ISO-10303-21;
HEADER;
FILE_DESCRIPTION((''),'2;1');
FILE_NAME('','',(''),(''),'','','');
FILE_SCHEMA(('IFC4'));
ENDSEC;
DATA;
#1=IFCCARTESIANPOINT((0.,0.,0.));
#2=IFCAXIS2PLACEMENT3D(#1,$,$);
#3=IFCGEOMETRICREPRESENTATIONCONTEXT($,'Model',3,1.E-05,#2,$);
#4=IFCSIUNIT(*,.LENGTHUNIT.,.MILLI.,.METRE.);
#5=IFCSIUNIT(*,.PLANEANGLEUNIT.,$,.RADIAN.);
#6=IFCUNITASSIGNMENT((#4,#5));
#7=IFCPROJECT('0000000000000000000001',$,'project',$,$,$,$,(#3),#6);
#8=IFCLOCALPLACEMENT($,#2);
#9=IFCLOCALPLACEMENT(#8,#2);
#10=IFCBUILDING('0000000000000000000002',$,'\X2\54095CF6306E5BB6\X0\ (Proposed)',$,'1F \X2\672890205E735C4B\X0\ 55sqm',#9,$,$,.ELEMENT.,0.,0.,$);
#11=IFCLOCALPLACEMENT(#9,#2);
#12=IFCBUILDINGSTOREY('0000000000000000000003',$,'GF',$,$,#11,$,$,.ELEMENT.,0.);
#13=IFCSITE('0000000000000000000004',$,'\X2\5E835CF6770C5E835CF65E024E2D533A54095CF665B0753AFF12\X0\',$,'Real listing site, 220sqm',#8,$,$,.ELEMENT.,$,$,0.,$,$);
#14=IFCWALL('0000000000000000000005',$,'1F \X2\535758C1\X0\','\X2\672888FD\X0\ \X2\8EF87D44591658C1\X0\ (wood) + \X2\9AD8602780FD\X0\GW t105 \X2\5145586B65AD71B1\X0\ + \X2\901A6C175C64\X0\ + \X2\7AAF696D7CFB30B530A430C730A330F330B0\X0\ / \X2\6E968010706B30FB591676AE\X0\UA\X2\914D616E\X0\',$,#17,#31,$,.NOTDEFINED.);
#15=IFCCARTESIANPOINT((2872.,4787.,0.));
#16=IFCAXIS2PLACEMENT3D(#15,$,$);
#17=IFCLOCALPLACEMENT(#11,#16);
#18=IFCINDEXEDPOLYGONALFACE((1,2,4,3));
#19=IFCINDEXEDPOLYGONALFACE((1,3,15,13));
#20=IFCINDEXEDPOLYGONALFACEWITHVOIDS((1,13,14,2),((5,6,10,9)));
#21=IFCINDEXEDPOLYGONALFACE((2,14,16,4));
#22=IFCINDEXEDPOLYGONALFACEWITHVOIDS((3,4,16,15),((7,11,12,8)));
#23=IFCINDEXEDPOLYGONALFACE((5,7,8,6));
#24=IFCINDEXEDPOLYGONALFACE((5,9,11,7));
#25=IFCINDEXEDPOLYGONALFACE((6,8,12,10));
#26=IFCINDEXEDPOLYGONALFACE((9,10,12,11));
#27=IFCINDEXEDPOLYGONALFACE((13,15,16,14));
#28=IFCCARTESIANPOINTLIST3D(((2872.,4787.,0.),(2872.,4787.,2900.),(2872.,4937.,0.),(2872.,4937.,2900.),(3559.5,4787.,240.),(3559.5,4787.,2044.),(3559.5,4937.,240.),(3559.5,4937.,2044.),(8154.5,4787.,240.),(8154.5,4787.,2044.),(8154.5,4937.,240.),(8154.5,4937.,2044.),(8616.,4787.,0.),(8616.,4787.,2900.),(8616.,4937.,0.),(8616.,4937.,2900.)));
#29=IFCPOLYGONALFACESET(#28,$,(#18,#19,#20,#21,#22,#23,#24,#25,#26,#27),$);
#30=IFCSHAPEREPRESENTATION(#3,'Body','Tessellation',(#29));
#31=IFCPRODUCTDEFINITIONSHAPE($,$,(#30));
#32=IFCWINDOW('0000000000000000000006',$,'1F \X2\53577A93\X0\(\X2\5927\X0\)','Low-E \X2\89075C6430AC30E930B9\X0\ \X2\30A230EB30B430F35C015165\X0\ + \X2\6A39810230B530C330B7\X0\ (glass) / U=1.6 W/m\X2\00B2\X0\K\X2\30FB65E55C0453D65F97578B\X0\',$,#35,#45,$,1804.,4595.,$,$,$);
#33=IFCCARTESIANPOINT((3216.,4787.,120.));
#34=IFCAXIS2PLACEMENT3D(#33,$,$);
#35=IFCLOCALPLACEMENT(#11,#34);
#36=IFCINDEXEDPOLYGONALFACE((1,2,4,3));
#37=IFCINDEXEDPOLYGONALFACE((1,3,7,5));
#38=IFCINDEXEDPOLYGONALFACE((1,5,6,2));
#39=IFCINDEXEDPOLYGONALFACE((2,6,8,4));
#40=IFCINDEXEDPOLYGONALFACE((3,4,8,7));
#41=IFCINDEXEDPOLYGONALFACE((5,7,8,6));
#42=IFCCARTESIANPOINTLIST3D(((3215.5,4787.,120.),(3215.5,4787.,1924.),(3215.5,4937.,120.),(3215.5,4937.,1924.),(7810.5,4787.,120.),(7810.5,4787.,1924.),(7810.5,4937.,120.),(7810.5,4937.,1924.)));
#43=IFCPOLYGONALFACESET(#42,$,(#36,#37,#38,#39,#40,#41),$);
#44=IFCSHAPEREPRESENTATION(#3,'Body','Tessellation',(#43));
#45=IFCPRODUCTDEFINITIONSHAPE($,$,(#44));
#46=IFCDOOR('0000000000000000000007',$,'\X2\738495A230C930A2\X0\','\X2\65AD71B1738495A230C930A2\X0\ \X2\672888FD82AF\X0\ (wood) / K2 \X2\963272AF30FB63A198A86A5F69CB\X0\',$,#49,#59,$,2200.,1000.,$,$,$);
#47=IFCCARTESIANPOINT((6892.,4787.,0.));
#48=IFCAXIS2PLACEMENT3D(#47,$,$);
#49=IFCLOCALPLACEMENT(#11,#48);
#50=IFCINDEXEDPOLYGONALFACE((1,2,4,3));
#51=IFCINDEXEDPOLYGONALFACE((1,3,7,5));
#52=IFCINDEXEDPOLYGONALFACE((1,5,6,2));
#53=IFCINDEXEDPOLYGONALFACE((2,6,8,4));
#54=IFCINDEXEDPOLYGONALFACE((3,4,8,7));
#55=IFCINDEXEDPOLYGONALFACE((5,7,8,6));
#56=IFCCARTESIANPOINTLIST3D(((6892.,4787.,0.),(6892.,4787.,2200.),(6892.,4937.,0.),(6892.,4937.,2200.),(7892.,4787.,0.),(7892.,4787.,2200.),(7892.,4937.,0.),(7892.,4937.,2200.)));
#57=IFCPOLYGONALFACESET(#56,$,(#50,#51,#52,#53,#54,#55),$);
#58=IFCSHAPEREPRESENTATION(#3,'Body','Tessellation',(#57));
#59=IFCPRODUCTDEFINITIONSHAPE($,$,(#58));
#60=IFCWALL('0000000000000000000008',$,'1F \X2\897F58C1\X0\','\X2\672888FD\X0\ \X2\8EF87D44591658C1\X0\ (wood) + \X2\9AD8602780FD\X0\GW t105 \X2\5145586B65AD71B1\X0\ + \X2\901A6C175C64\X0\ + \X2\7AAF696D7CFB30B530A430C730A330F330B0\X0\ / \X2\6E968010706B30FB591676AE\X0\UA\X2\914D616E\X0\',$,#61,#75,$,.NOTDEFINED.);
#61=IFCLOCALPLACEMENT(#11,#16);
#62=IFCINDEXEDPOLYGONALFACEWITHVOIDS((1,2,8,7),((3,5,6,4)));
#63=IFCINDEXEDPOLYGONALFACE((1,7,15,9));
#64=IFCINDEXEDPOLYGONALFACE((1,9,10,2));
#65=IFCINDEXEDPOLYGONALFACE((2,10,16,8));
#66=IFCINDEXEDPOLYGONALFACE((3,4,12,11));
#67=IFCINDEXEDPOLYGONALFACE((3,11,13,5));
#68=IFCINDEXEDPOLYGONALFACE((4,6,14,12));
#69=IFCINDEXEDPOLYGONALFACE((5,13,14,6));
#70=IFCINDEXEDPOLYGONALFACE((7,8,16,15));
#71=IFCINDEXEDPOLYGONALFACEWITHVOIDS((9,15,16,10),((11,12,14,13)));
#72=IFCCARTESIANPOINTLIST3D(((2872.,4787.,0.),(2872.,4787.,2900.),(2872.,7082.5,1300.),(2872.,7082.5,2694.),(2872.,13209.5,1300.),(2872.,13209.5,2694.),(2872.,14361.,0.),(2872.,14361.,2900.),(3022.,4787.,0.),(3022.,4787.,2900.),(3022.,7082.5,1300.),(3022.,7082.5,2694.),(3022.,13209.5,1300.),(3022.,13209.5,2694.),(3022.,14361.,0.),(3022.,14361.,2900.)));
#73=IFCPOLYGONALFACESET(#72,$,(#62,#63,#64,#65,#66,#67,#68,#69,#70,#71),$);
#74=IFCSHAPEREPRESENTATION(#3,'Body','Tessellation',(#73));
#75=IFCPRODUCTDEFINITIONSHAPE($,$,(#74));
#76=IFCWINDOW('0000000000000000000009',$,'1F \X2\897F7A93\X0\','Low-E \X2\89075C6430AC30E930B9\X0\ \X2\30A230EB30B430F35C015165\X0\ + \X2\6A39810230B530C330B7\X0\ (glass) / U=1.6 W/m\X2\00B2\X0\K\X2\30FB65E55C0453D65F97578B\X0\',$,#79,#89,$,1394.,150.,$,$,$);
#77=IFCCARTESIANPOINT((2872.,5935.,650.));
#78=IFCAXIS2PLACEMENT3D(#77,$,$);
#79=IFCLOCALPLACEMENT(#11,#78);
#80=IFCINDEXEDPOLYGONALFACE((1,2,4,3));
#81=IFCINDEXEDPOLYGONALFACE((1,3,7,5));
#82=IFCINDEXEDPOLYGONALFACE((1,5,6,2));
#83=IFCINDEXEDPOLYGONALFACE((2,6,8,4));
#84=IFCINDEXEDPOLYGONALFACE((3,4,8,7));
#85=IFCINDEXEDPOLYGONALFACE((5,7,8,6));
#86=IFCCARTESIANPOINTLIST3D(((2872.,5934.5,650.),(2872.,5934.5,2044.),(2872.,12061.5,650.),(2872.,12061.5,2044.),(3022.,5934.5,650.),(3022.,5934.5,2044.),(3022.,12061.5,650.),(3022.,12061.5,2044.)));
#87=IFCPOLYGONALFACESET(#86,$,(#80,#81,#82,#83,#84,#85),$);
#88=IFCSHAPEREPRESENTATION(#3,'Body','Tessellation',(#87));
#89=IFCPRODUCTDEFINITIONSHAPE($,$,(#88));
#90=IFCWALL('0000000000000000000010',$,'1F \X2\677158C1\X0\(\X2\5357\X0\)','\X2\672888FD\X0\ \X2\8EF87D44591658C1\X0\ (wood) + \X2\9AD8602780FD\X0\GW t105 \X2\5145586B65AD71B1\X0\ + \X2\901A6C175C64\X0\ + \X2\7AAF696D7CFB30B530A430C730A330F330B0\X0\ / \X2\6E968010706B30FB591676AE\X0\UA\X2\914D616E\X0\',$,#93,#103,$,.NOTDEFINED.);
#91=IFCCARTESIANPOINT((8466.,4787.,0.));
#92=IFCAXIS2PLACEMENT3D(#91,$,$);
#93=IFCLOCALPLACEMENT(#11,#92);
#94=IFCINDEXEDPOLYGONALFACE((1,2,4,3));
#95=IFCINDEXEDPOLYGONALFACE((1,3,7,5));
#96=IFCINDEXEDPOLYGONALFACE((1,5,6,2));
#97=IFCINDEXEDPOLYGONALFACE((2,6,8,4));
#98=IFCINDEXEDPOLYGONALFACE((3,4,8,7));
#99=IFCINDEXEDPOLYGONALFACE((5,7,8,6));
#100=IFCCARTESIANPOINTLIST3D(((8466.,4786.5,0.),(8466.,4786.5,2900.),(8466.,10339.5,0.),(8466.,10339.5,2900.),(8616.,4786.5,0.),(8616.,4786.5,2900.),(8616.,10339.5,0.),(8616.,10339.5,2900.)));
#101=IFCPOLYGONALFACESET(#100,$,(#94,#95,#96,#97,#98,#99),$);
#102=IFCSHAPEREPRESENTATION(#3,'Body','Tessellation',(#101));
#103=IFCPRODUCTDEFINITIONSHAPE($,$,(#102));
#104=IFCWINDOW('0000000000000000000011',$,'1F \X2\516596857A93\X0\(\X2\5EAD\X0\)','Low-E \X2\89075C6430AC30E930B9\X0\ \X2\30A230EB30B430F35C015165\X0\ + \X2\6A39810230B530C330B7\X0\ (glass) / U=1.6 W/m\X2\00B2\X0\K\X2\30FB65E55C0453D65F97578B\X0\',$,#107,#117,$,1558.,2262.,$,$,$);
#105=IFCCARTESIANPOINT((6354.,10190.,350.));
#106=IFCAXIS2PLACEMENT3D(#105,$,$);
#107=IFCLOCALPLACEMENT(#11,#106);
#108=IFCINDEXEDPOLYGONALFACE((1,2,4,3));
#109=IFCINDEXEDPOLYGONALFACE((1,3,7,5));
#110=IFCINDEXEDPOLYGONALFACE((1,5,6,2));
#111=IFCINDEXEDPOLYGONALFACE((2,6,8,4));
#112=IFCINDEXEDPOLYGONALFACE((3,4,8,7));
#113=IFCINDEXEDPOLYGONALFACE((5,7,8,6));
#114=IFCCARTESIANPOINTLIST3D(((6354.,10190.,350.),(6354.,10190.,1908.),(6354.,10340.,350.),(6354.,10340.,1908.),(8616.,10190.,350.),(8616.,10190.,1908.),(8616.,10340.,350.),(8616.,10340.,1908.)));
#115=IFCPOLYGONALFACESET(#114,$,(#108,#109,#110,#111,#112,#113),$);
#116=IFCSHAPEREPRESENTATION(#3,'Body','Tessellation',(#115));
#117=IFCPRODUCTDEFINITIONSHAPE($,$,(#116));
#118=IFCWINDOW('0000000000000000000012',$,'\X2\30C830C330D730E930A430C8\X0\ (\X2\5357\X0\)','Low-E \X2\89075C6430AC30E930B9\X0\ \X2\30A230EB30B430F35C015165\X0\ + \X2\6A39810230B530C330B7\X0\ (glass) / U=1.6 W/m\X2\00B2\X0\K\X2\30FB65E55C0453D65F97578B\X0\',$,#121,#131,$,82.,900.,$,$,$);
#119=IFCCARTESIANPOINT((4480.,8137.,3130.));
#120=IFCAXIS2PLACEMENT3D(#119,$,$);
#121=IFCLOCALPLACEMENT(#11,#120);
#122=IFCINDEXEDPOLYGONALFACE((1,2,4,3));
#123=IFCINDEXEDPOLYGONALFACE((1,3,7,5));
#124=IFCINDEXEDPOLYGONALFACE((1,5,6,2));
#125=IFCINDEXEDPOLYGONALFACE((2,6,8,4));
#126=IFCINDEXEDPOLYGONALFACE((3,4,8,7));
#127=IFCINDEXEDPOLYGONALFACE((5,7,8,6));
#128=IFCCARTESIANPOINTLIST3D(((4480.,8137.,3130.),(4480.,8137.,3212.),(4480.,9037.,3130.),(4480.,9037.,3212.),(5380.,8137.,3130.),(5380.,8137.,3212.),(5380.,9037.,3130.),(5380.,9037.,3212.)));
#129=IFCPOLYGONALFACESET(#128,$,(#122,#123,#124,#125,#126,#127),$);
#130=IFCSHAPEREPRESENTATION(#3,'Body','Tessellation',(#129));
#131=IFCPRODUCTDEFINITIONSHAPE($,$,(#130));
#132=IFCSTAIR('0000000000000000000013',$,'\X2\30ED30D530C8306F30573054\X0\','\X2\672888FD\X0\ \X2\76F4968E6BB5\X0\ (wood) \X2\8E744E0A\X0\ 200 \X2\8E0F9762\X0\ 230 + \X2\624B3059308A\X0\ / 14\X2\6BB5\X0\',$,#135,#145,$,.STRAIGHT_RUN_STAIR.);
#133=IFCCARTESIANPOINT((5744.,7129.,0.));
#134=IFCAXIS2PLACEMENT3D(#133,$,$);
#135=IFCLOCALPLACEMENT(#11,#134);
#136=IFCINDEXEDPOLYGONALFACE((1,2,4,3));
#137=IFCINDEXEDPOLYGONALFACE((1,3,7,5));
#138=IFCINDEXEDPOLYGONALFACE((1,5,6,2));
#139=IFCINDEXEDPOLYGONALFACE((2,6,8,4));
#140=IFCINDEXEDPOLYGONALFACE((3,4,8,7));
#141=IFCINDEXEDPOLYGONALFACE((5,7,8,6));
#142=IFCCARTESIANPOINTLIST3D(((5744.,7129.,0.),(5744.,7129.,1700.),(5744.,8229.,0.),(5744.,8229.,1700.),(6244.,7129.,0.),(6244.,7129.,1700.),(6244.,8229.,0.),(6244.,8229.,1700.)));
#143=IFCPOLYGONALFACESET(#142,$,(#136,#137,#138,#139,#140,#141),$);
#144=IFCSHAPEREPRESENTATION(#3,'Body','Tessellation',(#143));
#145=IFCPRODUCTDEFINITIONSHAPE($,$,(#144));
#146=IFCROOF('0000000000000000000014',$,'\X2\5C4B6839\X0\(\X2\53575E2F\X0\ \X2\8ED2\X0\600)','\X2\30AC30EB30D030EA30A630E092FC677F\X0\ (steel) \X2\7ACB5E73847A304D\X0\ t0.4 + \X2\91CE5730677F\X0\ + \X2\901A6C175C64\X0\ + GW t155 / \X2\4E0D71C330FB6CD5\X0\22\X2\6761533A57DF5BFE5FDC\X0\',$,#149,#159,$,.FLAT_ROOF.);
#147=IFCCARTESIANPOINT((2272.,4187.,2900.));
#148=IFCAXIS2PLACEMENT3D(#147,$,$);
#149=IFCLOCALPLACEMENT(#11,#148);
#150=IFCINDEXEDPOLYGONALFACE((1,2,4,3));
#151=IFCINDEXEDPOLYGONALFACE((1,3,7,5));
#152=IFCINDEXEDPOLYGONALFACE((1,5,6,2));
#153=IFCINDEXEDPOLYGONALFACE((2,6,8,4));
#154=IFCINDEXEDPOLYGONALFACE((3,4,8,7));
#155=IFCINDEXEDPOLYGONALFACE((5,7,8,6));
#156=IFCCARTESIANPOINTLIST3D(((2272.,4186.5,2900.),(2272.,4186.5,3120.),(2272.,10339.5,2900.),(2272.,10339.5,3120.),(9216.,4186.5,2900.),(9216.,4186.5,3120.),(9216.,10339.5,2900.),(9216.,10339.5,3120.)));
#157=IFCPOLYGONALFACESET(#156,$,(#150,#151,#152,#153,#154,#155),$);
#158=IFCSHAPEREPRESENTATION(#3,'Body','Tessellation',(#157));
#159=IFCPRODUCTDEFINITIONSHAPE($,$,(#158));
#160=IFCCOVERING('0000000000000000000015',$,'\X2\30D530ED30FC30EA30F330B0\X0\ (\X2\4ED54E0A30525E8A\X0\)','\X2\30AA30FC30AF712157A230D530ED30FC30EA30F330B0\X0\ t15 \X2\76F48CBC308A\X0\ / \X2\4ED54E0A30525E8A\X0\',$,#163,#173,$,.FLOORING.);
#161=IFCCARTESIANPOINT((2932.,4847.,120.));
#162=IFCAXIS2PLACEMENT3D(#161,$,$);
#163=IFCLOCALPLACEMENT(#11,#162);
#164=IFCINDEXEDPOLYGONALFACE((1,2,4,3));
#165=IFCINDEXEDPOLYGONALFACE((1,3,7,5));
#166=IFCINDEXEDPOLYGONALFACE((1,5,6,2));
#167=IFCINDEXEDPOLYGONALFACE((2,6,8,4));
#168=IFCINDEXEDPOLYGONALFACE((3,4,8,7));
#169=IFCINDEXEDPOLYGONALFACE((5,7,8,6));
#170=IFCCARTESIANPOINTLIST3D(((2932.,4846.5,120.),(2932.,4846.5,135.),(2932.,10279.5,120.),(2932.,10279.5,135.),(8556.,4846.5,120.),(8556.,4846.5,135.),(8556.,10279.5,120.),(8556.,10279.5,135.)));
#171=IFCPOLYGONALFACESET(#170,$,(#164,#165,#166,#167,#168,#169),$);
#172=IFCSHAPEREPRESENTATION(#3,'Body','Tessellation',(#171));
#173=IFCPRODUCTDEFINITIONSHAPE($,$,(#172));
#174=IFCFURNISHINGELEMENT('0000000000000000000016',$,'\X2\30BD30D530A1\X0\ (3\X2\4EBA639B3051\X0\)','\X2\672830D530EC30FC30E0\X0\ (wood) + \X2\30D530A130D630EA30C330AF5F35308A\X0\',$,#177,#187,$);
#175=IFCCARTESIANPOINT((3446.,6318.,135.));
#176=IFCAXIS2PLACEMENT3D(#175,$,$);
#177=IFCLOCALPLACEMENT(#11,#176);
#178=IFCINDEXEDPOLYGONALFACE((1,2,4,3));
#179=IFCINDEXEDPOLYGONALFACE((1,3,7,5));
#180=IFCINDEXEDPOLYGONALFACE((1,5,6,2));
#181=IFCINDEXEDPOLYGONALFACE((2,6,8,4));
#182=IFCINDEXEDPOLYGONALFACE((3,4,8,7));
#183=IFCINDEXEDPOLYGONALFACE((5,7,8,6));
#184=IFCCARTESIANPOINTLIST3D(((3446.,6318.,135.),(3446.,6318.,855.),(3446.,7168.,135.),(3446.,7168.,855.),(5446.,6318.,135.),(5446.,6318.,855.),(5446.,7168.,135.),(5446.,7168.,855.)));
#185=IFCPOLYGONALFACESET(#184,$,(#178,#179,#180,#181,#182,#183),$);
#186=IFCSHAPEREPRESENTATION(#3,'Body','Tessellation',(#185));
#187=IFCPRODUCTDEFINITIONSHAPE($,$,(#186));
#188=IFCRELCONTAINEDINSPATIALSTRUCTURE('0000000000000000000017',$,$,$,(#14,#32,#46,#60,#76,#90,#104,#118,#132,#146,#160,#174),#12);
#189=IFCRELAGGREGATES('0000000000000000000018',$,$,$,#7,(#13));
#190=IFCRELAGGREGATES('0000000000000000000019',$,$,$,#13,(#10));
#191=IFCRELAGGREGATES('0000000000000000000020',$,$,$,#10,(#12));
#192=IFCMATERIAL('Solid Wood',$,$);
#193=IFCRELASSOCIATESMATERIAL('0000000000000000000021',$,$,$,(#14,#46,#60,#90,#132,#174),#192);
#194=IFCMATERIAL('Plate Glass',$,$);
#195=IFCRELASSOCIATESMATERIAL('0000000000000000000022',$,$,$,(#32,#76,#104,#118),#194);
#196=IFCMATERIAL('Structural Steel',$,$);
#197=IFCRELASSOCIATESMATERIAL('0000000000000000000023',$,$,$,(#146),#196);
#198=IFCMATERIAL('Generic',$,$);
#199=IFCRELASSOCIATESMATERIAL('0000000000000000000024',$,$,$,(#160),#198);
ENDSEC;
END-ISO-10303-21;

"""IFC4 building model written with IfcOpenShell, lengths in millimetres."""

from ifc_helpers import new_model, si_unit, frame, frame_2d, origin, place, context, project, spatial, rectangle, extrude, material, element, fill, save


model = new_model("IFC4")

# Units and contexts
model_context = context("Model", 3, precision=1e-05, world=origin())
ifc_project = project(units=[si_unit("LENGTHUNIT", "METRE", prefix="MILLI"), si_unit("PLANEANGLEUNIT", "RADIAN")], contexts=[model_context])

# Site, building, storey
site_placement = place(None, origin())
site = spatial("IfcSite", under=ifc_project, at=site_placement, Name="広島県広島市中区吉島新町２", ObjectType="Real listing site, 220sqm", CompositionType="ELEMENT", RefElevation=0.0)
building_placement = place(site_placement, origin())
building = spatial("IfcBuilding", under=site, at=building_placement, Name="吉島の家 (Proposed)", ObjectType="1F 木造平屋 55sqm", CompositionType="ELEMENT", ElevationOfRefHeight=0.0, ElevationOfTerrain=0.0)
storey_placement = place(building_placement, origin())
storey = spatial("IfcBuildingStorey", under=building, at=storey_placement, Name="GF", CompositionType="ELEMENT", Elevation=0.0)

# Shared definitions
ifc_material_1 = material(Name="Solid Wood")

# Wall, openings, window, door
wall_1_placement = place(storey_placement, frame((2872.0, 4787.0, 0.0)))
wall_1 = element("IfcWall", 1, at=wall_1_placement, inside=storey, material=ifc_material_1, Name="1F 南壁", Description="木製 軸組外壁 (wood) + 高性能GW t105 充填断熱 + 通気層 + 窯業系サイディング / 準耐火・外皮UA配慮", PredefinedType="NOTDEFINED", context=model_context, shape_type="SweptSolid", body=[
    extrude(rectangle(XDim=5744.0, YDim=150.0, at=frame_2d((2872.0, 75.0))), frame((2872.0, 4787.0, 0.0)), (0.0, 0.0, 1.0), 2900.0),
])
opening_1_placement = place(storey_placement, frame((3216.0, 4787.0, 120.0)))
opening_1 = element("IfcOpeningElement", 2, at=opening_1_placement, cuts=wall_1, PredefinedType="NOTDEFINED", context=model_context, shape_type="SweptSolid", body=[
    extrude(rectangle(XDim=4595.0, YDim=150.0, at=frame_2d((2297.0, 75.0))), frame((3216.0, 4787.0, 120.0)), (0.0, 0.0, 1.0), 1804.0),
])
opening_2_placement = place(storey_placement, frame((6892.0, 4787.0, 0.0)))
opening_2 = element("IfcOpeningElement", 3, at=opening_2_placement, cuts=wall_1, PredefinedType="NOTDEFINED", context=model_context, shape_type="SweptSolid", body=[
    extrude(rectangle(XDim=1000.0, YDim=150.0, at=frame_2d((500.0, 75.0))), frame((6892.0, 4787.0, 0.0)), (0.0, 0.0, 1.0), 2200.0),
])
ifc_material_2 = material(Name="Plate Glass")
window_1_placement = place(storey_placement, frame((3216.0, 4787.0, 120.0)))
window_1 = element("IfcWindow", 4, at=window_1_placement, inside=storey, material=ifc_material_2, Name="1F 南窓(大)", Description="Low-E 複層ガラス アルゴン封入 + 樹脂サッシ (glass) / U=1.6 W/m²K・日射取得型", OverallHeight=1804.0, OverallWidth=4595.0, context=model_context, shape_type="SweptSolid", body=[
    extrude(rectangle(XDim=4595.0, YDim=150.0, at=frame_2d((2297.0, 75.0))), frame((3216.0, 4787.0, 120.0)), (0.0, 0.0, 1.0), 1804.0),
])
fill(opening_1, window_1)
door_1_placement = place(storey_placement, frame((6892.0, 4787.0, 0.0)))
door_1 = element("IfcDoor", 5, at=door_1_placement, inside=storey, material=ifc_material_1, Name="玄関ドア", Description="断熱玄関ドア 木製芯 (wood) / K2 防犯・採風機構", OverallHeight=2200.0, OverallWidth=1000.0, context=model_context, shape_type="SweptSolid", body=[
    extrude(rectangle(XDim=1000.0, YDim=150.0, at=frame_2d((500.0, 75.0))), frame((6892.0, 4787.0, 0.0)), (0.0, 0.0, 1.0), 2200.0),
])
fill(opening_2, door_1)

# Walls, openings, windows
wall_2_placement = place(storey_placement, frame((2872.0, 4787.0, 0.0)))
wall_2 = element("IfcWall", 6, at=wall_2_placement, inside=storey, material=ifc_material_1, Name="1F 西壁", Description="木製 軸組外壁 (wood) + 高性能GW t105 充填断熱 + 通気層 + 窯業系サイディング / 準耐火・外皮UA配慮", PredefinedType="NOTDEFINED", context=model_context, shape_type="SweptSolid", body=[
    extrude(rectangle(XDim=150.0, YDim=9574.0, at=frame_2d((75.0, 4787.0))), frame((2872.0, 4787.0, 0.0)), (0.0, 0.0, 1.0), 2900.0),
])
opening_3_placement = place(storey_placement, frame((2872.0, 5935.0, 650.0)))
opening_3 = element("IfcOpeningElement", 7, at=opening_3_placement, cuts=wall_2, PredefinedType="NOTDEFINED", context=model_context, shape_type="SweptSolid", body=[
    extrude(rectangle(XDim=150.0, YDim=6127.0, at=frame_2d((75.0, 3063.0))), frame((2872.0, 5935.0, 650.0)), (0.0, 0.0, 1.0), 1394.0),
])
window_2_placement = place(storey_placement, frame((2872.0, 5935.0, 650.0)))
window_2 = element("IfcWindow", 8, at=window_2_placement, inside=storey, material=ifc_material_2, Name="1F 西窓", Description="Low-E 複層ガラス アルゴン封入 + 樹脂サッシ (glass) / U=1.6 W/m²K・日射取得型", OverallHeight=1394.0, OverallWidth=150.0, context=model_context, shape_type="SweptSolid", body=[
    extrude(rectangle(XDim=150.0, YDim=6127.0, at=frame_2d((75.0, 3063.0))), frame((2872.0, 5935.0, 650.0)), (0.0, 0.0, 1.0), 1394.0),
])
fill(opening_3, window_2)
wall_3_placement = place(storey_placement, frame((8466.0, 4787.0, 0.0)))
wall_3 = element("IfcWall", 9, at=wall_3_placement, inside=storey, material=ifc_material_1, Name="1F 東壁(南)", Description="木製 軸組外壁 (wood) + 高性能GW t105 充填断熱 + 通気層 + 窯業系サイディング / 準耐火・外皮UA配慮", PredefinedType="NOTDEFINED", context=model_context, shape_type="SweptSolid", body=[
    extrude(rectangle(XDim=150.0, YDim=5553.0, at=frame_2d((75.0, 2776.0))), frame((8466.0, 4787.0, 0.0)), (0.0, 0.0, 1.0), 2900.0),
])
opening_4_placement = place(storey_placement, frame((6354.0, 10190.0, 350.0)))
opening_4 = element("IfcOpeningElement", 10, at=opening_4_placement, cuts=wall_3, PredefinedType="NOTDEFINED", context=model_context, shape_type="SweptSolid", body=[
    extrude(rectangle(XDim=2262.0, YDim=150.0, at=frame_2d((1131.0, 75.0))), frame((6354.0, 10190.0, 350.0)), (0.0, 0.0, 1.0), 1558.0),
])
window_3_placement = place(storey_placement, frame((6354.0, 10190.0, 350.0)))
window_3 = element("IfcWindow", 11, at=window_3_placement, inside=storey, material=ifc_material_2, Name="1F 入隅窓(庭)", Description="Low-E 複層ガラス アルゴン封入 + 樹脂サッシ (glass) / U=1.6 W/m²K・日射取得型", OverallHeight=1558.0, OverallWidth=2262.0, context=model_context, shape_type="SweptSolid", body=[
    extrude(rectangle(XDim=2262.0, YDim=150.0, at=frame_2d((1131.0, 75.0))), frame((6354.0, 10190.0, 350.0)), (0.0, 0.0, 1.0), 1558.0),
])
fill(opening_4, window_3)

# Window
window_4_placement = place(storey_placement, frame((4480.0, 8137.0, 3130.0)))
element("IfcWindow", 12, at=window_4_placement, inside=storey, material=ifc_material_2, Name="トップライト (南)", Description="Low-E 複層ガラス アルゴン封入 + 樹脂サッシ (glass) / U=1.6 W/m²K・日射取得型", OverallHeight=82.0, OverallWidth=900.0, context=model_context, shape_type="SweptSolid", body=[
    extrude(rectangle(XDim=900.0, YDim=900.0, at=frame_2d((450.0, 450.0))), frame((4480.0, 8137.0, 3130.0)), (0.0, 0.0, 1.0), 82.0),
])

# Stair
stair_placement = place(storey_placement, frame((5744.0, 7129.0, 0.0)))
element("IfcStair", 13, at=stair_placement, inside=storey, material=ifc_material_1, Name="ロフトはしご", Description="木製 直階段 (wood) 蹴上 200 踏面 230 + 手すり / 14段", PredefinedType="STRAIGHT_RUN_STAIR", context=model_context, shape_type="SweptSolid", body=[
    extrude(rectangle(XDim=500.0, YDim=1100.0, at=frame_2d((250.0, 550.0))), frame((5744.0, 7129.0, 0.0)), (0.0, 0.0, 1.0), 1700.0),
])

# Roof
ifc_material_3 = material(Name="Structural Steel")
roof_placement = place(storey_placement, frame((2272.0, 4187.0, 2900.0)))
element("IfcRoof", 14, at=roof_placement, inside=storey, material=ifc_material_3, Name="屋根(南帯 軒600)", Description="ガルバリウム鋼板 (steel) 立平葺き t0.4 + 野地板 + 通気層 + GW t155 / 不燃・法22条区域対応", PredefinedType="FLAT_ROOF", context=model_context, shape_type="SweptSolid", body=[
    extrude(rectangle(XDim=6944.0, YDim=6153.0, at=frame_2d((3472.0, 3076.0))), frame((2272.0, 4187.0, 2900.0)), (0.0, 0.0, 1.0), 220.0),
])

# Covering
ifc_material_4 = material(Name="Generic")
covering_placement = place(storey_placement, frame((2932.0, 4847.0, 120.0)))
element("IfcCovering", 15, at=covering_placement, inside=storey, material=ifc_material_4, Name="フローリング (仕上げ床)", Description="オーク無垢フローリング t15 直貼り / 仕上げ床", PredefinedType="FLOORING", context=model_context, shape_type="SweptSolid", body=[
    extrude(rectangle(XDim=5624.0, YDim=5433.0, at=frame_2d((2812.0, 2716.0))), frame((2932.0, 4847.0, 120.0)), (0.0, 0.0, 1.0), 15.0),
])

# Furnishing element
furnishing_1_placement = place(storey_placement, frame((3446.0, 6318.0, 135.0)))
element("IfcFurnishingElement", 16, at=furnishing_1_placement, inside=storey, material=ifc_material_1, Name="ソファ (3人掛け)", Description="木フレーム (wood) + ファブリック張り", context=model_context, shape_type="SweptSolid", body=[
    extrude(rectangle(XDim=2000.0, YDim=850.0, at=frame_2d((1000.0, 425.0))), frame((3446.0, 6318.0, 135.0)), (0.0, 0.0, 1.0), 720.0),
])

save(model, "model.ifc")
